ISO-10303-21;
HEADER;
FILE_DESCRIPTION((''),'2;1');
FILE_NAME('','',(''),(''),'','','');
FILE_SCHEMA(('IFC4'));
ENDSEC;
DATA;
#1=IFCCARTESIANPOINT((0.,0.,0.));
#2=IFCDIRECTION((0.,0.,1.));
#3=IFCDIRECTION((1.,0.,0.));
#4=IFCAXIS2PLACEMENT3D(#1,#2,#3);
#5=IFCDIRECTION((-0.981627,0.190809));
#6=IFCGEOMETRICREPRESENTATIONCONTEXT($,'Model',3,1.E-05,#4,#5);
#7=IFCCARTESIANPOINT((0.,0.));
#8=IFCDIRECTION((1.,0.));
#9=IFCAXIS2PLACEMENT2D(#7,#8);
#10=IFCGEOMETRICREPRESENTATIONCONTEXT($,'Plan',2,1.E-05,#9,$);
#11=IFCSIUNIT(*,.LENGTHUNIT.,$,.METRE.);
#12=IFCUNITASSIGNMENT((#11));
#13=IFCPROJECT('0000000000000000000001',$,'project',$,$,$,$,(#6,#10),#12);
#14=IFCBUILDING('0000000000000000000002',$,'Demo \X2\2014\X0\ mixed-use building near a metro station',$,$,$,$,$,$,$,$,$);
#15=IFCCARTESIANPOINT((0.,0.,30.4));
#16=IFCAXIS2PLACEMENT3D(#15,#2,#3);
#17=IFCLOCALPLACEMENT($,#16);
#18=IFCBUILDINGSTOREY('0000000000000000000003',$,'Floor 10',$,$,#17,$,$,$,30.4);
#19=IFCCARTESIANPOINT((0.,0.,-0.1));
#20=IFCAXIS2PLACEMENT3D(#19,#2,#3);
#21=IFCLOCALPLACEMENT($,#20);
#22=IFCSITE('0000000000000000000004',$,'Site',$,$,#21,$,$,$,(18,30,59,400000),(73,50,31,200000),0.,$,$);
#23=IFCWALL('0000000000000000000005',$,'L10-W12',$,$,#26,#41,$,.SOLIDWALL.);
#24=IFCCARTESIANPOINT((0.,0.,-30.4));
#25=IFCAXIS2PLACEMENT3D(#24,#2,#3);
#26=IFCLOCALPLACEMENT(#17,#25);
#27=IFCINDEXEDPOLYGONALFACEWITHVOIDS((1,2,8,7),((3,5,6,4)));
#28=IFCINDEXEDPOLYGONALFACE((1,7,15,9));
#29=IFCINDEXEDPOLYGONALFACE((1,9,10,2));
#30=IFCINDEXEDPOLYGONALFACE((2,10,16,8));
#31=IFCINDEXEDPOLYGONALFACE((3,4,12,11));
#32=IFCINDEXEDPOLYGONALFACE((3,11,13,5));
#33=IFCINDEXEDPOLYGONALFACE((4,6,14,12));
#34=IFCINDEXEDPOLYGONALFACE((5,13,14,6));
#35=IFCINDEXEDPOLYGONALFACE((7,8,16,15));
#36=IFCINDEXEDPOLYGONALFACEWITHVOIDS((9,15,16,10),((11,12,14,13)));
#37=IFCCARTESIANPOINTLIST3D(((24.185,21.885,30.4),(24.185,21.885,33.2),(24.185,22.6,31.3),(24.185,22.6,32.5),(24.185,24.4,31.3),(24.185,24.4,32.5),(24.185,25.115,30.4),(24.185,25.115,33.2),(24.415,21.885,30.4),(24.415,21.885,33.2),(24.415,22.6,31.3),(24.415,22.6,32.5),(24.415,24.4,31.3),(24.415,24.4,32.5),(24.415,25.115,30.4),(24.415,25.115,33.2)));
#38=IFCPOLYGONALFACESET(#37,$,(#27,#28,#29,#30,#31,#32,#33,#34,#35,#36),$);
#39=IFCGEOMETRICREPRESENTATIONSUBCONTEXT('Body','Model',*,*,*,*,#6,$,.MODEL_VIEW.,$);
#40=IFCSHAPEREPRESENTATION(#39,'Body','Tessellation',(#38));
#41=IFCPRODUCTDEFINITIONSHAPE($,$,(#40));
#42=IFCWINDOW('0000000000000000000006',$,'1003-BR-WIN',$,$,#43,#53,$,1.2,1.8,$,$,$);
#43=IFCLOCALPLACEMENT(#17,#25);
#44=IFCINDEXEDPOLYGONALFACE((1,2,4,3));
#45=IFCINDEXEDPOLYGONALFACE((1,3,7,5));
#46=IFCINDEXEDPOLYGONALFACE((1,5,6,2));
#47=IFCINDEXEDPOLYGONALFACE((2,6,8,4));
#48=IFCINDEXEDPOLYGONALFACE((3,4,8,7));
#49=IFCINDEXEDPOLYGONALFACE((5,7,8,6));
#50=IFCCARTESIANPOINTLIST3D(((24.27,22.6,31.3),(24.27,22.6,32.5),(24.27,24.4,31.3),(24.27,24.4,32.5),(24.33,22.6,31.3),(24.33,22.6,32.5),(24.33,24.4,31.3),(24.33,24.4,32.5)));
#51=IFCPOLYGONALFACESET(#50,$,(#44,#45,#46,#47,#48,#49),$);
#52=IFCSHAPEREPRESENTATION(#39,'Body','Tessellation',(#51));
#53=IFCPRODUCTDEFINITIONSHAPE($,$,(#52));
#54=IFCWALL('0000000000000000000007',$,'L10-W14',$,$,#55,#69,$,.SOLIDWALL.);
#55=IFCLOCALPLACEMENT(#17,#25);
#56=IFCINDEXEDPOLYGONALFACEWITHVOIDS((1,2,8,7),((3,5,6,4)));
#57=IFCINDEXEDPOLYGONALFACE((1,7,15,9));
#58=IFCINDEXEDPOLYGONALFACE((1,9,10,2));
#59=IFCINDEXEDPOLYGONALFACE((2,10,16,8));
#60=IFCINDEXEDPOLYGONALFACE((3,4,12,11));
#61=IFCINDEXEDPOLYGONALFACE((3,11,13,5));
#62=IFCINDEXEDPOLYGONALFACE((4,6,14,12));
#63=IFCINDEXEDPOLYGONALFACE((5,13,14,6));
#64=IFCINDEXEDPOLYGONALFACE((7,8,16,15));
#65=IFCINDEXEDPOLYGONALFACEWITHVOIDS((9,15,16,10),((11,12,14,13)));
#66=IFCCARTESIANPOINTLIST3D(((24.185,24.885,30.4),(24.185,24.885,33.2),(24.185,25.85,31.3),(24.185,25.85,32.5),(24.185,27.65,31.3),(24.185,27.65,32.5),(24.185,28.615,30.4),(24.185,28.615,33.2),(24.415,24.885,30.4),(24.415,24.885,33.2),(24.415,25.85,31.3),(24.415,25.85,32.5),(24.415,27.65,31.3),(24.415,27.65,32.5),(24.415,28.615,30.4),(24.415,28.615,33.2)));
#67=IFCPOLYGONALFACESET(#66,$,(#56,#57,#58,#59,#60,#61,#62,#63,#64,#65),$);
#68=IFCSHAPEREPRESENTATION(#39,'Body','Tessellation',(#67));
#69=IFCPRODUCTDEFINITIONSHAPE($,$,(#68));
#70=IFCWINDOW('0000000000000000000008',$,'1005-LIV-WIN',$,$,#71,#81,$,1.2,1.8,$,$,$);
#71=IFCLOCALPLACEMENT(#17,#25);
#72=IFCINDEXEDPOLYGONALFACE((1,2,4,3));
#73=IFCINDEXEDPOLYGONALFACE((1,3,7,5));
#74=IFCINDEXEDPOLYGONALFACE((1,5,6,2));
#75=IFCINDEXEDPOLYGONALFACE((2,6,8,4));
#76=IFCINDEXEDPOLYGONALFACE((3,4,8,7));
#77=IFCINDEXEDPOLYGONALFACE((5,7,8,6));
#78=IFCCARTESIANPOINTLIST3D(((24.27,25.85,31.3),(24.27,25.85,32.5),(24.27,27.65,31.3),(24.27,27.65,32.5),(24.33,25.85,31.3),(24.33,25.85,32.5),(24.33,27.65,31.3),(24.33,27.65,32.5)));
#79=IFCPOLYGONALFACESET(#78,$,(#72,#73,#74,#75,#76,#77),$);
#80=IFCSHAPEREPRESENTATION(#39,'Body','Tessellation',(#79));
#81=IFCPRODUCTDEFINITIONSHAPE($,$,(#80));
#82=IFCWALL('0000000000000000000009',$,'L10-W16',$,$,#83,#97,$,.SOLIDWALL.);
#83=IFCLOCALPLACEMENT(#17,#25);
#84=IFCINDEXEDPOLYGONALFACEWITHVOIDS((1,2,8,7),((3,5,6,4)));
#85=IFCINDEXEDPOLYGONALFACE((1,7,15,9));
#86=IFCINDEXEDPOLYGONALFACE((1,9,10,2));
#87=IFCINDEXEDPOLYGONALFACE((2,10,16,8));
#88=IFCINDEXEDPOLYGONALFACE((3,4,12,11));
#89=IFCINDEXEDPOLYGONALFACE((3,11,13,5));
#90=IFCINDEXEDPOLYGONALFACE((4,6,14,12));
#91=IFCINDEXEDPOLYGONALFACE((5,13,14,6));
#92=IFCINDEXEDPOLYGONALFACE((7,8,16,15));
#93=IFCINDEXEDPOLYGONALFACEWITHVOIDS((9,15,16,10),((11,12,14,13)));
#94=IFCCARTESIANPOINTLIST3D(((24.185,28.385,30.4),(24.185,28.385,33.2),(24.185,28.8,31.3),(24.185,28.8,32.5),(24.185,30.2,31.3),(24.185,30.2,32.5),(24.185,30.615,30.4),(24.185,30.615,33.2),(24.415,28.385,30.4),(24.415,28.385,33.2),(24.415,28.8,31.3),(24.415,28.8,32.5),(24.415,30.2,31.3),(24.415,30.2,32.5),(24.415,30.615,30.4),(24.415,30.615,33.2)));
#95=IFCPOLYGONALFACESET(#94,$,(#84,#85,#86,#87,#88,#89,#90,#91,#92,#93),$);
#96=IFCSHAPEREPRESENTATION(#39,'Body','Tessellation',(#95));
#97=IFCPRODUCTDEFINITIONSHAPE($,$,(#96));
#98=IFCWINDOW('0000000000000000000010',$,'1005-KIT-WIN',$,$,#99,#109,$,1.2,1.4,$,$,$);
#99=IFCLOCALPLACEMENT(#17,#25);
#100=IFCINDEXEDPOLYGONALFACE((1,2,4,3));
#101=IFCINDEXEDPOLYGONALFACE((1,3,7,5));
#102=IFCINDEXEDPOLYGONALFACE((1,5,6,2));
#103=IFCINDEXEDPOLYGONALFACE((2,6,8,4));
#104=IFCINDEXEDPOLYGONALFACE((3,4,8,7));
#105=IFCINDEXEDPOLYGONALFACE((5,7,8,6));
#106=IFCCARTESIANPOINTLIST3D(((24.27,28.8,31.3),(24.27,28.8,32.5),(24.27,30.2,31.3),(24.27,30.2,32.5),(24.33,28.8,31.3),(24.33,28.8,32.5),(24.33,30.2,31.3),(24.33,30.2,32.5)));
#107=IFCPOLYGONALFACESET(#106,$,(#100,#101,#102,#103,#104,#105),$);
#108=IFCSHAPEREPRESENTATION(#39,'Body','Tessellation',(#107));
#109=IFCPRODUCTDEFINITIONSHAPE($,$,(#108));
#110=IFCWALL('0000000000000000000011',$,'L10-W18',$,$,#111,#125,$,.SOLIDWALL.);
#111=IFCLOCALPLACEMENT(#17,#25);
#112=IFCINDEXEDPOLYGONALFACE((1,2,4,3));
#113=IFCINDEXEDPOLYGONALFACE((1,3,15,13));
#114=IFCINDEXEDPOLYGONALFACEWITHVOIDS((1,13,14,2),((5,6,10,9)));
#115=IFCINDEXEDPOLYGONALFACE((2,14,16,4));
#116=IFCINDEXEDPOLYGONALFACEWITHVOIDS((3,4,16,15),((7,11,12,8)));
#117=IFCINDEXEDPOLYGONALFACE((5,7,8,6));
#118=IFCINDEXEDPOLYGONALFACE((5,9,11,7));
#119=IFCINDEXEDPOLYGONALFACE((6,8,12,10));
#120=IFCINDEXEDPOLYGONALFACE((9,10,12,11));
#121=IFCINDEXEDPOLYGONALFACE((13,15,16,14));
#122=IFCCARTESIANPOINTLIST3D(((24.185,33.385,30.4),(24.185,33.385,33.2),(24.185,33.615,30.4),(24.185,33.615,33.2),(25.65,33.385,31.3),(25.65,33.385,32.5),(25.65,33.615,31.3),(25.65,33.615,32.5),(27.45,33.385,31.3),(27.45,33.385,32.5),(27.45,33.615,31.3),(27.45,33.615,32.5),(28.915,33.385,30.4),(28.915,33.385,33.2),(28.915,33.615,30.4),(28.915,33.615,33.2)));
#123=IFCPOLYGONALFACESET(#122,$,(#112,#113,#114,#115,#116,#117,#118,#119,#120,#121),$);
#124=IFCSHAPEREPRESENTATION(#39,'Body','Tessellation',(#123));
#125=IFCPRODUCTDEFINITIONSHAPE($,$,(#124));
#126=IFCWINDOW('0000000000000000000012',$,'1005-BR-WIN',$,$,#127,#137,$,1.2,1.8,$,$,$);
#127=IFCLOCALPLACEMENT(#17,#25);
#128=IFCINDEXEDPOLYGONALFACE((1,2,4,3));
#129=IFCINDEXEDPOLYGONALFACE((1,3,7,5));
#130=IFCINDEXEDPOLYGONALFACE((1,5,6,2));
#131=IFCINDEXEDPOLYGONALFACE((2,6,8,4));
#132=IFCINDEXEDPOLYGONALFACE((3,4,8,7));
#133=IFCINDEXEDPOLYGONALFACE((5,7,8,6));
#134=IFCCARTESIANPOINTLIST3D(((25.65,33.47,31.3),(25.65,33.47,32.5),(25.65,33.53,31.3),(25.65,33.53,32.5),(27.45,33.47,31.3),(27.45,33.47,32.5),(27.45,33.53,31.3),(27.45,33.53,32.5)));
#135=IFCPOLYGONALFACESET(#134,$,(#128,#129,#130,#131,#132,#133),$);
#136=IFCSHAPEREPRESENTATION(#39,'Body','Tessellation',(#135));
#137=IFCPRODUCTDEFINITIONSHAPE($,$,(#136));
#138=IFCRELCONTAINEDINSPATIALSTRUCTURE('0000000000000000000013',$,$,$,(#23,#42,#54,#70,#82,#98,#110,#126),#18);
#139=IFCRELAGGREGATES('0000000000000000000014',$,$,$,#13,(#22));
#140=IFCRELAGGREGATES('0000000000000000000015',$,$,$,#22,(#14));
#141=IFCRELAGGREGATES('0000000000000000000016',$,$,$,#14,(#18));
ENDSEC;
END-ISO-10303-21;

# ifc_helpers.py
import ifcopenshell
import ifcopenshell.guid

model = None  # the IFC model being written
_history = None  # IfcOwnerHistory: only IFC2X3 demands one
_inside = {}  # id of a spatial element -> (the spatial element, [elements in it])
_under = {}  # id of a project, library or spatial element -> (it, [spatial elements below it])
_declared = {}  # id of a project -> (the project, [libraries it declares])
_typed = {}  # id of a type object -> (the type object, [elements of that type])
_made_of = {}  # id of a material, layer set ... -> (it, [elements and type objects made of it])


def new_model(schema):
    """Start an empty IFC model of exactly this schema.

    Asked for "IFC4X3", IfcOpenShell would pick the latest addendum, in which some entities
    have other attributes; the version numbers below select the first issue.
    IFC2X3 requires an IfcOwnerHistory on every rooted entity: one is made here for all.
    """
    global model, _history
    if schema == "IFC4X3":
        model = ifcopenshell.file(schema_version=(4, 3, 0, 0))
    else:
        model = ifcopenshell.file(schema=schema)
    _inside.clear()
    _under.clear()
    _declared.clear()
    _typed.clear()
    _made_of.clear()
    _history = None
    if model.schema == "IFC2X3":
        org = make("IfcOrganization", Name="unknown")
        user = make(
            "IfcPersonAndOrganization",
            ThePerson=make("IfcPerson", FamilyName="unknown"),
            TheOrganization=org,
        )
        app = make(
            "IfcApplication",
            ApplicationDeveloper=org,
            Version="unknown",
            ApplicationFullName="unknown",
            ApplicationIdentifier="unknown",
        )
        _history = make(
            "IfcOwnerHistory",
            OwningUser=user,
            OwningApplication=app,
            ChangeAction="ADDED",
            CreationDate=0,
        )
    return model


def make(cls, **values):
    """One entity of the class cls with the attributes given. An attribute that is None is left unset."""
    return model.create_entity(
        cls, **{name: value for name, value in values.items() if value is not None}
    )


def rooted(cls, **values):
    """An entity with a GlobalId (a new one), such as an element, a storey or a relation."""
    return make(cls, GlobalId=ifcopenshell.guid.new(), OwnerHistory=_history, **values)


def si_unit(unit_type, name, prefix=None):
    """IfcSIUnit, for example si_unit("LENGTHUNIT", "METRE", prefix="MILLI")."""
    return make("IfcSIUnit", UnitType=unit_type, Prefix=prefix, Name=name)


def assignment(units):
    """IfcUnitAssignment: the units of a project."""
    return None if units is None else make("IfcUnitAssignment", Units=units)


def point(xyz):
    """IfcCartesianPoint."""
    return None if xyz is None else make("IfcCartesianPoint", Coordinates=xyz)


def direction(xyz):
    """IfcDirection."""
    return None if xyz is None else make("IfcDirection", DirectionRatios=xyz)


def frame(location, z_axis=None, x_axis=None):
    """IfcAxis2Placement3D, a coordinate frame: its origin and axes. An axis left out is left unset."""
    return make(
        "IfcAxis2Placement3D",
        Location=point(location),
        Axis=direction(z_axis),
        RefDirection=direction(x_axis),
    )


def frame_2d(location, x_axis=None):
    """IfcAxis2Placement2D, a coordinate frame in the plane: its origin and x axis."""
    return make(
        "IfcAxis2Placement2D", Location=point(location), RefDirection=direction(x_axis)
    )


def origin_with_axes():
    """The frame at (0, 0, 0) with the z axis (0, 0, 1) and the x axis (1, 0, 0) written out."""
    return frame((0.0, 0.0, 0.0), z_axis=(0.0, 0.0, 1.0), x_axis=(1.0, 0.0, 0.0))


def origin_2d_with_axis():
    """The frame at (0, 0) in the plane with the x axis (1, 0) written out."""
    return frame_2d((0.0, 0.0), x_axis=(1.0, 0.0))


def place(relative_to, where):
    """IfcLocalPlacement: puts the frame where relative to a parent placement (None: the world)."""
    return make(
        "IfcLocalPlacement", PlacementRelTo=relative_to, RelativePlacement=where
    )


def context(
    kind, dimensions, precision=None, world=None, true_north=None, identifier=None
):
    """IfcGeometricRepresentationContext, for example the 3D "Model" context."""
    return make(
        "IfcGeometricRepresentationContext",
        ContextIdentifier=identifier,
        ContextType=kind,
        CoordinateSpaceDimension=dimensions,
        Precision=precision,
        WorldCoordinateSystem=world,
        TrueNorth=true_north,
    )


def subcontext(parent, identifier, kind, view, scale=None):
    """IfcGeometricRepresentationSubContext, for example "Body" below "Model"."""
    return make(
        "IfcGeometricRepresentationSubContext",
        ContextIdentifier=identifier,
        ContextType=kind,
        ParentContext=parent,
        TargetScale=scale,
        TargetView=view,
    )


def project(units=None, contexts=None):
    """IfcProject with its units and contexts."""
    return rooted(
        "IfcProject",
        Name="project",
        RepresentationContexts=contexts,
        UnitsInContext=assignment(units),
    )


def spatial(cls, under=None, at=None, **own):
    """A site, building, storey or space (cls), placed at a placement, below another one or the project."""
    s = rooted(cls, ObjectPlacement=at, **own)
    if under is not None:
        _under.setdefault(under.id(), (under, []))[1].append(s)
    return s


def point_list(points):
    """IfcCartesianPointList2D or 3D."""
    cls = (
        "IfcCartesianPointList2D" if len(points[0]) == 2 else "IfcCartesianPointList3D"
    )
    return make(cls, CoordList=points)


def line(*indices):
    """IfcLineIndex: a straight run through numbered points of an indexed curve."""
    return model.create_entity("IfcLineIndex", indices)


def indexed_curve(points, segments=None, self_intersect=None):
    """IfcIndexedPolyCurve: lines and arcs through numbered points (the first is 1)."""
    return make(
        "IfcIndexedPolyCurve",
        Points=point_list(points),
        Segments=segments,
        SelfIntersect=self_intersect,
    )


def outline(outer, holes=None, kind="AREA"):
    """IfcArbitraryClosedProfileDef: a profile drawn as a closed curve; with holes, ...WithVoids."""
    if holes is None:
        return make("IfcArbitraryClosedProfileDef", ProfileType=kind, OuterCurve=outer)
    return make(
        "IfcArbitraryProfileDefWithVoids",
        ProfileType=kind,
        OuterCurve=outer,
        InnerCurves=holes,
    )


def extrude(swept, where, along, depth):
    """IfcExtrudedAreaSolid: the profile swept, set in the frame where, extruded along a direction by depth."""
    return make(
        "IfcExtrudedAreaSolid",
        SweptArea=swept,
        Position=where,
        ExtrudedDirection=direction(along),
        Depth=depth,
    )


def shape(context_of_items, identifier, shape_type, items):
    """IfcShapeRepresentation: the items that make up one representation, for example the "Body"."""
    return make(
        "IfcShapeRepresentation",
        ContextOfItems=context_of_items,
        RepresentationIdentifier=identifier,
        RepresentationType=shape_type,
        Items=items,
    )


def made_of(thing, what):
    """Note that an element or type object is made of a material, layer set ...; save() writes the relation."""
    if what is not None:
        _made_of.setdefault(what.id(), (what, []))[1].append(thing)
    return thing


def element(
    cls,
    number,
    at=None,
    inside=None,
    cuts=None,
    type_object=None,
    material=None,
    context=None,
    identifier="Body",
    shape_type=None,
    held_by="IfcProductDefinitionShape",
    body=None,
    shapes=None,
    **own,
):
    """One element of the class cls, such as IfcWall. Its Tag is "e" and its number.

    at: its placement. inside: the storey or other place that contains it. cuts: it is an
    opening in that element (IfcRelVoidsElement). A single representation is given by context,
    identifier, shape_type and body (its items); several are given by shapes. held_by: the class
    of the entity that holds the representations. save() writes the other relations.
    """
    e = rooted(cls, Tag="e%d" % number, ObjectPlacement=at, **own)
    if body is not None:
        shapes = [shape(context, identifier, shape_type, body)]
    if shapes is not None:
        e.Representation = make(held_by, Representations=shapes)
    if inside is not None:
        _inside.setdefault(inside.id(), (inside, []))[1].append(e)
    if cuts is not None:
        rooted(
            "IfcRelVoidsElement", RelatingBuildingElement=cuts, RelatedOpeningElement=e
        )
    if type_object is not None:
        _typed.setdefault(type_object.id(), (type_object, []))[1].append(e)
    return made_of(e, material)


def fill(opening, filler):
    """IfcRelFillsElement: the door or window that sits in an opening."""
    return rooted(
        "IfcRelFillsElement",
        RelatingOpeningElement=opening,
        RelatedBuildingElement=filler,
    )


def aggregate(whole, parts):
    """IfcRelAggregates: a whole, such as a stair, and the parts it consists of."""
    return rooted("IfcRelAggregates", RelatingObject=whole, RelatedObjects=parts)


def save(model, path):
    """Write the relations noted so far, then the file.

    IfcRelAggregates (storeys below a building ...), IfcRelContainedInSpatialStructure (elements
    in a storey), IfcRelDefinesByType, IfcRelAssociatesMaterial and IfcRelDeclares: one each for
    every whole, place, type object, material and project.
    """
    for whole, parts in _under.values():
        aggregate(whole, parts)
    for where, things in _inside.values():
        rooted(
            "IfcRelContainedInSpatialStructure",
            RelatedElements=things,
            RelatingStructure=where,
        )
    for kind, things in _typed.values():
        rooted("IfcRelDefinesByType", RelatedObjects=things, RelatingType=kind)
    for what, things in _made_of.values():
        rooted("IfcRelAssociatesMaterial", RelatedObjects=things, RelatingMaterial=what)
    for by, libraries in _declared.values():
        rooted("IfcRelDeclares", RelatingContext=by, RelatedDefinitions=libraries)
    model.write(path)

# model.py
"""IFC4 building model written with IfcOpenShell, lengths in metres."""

from ifc_helpers import new_model, si_unit, direction, frame, origin_with_axes, origin_2d_with_axis, place, context, subcontext, project, spatial, line, indexed_curve, outline, extrude, element, fill, save


model = new_model("IFC4")

# Units and contexts
model_context = context("Model", 3, precision=1e-05, world=origin_with_axes(), true_north=direction((-0.981627, 0.190809)))
plan_context = context("Plan", 2, precision=1e-05, world=origin_2d_with_axis())
body_context = subcontext(model_context, "Body", "Model", "MODEL_VIEW")
ifc_project = project(units=[si_unit("LENGTHUNIT", "METRE")], contexts=[model_context, plan_context])

# Site, building, storey
site_placement = place(None, frame((0.0, 0.0, -0.1), z_axis=(0.0, 0.0, 1.0), x_axis=(1.0, 0.0, 0.0)))
site = spatial("IfcSite", under=ifc_project, at=site_placement, Name="Site", RefLatitude=(18, 30, 59, 400000), RefLongitude=(73, 50, 31, 200000), RefElevation=0.0)
building = spatial("IfcBuilding", under=site, Name="Demo — mixed-use building near a metro station")
storey_placement = place(None, frame((0.0, 0.0, 30.4), z_axis=(0.0, 0.0, 1.0), x_axis=(1.0, 0.0, 0.0)))
storey = spatial("IfcBuildingStorey", under=building, at=storey_placement, Name="Floor 10", Elevation=30.4)

# Wall, opening, window
wall_1_placement = place(storey_placement, frame((0.0, 0.0, -30.4), z_axis=(0.0, 0.0, 1.0), x_axis=(1.0, 0.0, 0.0)))
wall_1 = element("IfcWall", 1, at=wall_1_placement, inside=storey, Name="L10-W12", PredefinedType="SOLIDWALL", context=body_context, shape_type="SweptSolid", body=[
    extrude(outline(indexed_curve([(24.415, 25.115), (24.415, 21.885), (24.185, 21.885), (24.185, 25.115)], segments=[line(1, 2, 3, 4, 1)])), frame((0.0, 0.0, 30.4), z_axis=(0.0, 0.0, 1.0), x_axis=(1.0, 0.0, 0.0)), (0.0, 0.0, 1.0), 2.8),
])
opening_1_placement = place(wall_1_placement, origin_with_axes())
opening_1 = element("IfcOpeningElement", 2, at=opening_1_placement, cuts=wall_1, context=body_context, shape_type="SweptSolid", body=[
    extrude(outline(indexed_curve([(24.465, 24.4), (24.465, 22.6), (24.135, 22.6), (24.135, 24.4)], segments=[line(1, 2, 3, 4, 1)])), frame((0.0, 0.0, 31.3), z_axis=(0.0, 0.0, 1.0), x_axis=(1.0, 0.0, 0.0)), (0.0, 0.0, 1.0), 1.2),
])
window_1_placement = place(storey_placement, frame((0.0, 0.0, -30.4), z_axis=(0.0, 0.0, 1.0), x_axis=(1.0, 0.0, 0.0)))
window_1 = element("IfcWindow", 3, at=window_1_placement, inside=storey, Name="1003-BR-WIN", OverallHeight=1.2, OverallWidth=1.8, context=body_context, shape_type="SweptSolid", body=[
    extrude(outline(indexed_curve([(24.33, 24.4), (24.33, 22.6), (24.27, 22.6), (24.27, 24.4)], segments=[line(1, 2, 3, 4, 1)])), frame((0.0, 0.0, 31.3), z_axis=(0.0, 0.0, 1.0), x_axis=(1.0, 0.0, 0.0)), (0.0, 0.0, 1.0), 1.2),
])
fill(opening_1, window_1)

# Wall, opening, window
wall_2_placement = place(storey_placement, frame((0.0, 0.0, -30.4), z_axis=(0.0, 0.0, 1.0), x_axis=(1.0, 0.0, 0.0)))
wall_2 = element("IfcWall", 4, at=wall_2_placement, inside=storey, Name="L10-W14", PredefinedType="SOLIDWALL", context=body_context, shape_type="SweptSolid", body=[
    extrude(outline(indexed_curve([(24.415, 28.615), (24.415, 24.885), (24.185, 24.885), (24.185, 28.615)], segments=[line(1, 2, 3, 4, 1)])), frame((0.0, 0.0, 30.4), z_axis=(0.0, 0.0, 1.0), x_axis=(1.0, 0.0, 0.0)), (0.0, 0.0, 1.0), 2.8),
])
opening_2_placement = place(wall_2_placement, origin_with_axes())
opening_2 = element("IfcOpeningElement", 5, at=opening_2_placement, cuts=wall_2, context=body_context, shape_type="SweptSolid", body=[
    extrude(outline(indexed_curve([(24.465, 27.65), (24.465, 25.85), (24.135, 25.85), (24.135, 27.65)], segments=[line(1, 2, 3, 4, 1)])), frame((0.0, 0.0, 31.3), z_axis=(0.0, 0.0, 1.0), x_axis=(1.0, 0.0, 0.0)), (0.0, 0.0, 1.0), 1.2),
])
window_2_placement = place(storey_placement, frame((0.0, 0.0, -30.4), z_axis=(0.0, 0.0, 1.0), x_axis=(1.0, 0.0, 0.0)))
window_2 = element("IfcWindow", 6, at=window_2_placement, inside=storey, Name="1005-LIV-WIN", OverallHeight=1.2, OverallWidth=1.8, context=body_context, shape_type="SweptSolid", body=[
    extrude(outline(indexed_curve([(24.33, 27.65), (24.33, 25.85), (24.27, 25.85), (24.27, 27.65)], segments=[line(1, 2, 3, 4, 1)])), frame((0.0, 0.0, 31.3), z_axis=(0.0, 0.0, 1.0), x_axis=(1.0, 0.0, 0.0)), (0.0, 0.0, 1.0), 1.2),
])
fill(opening_2, window_2)

# Wall, opening, window
wall_3_placement = place(storey_placement, frame((0.0, 0.0, -30.4), z_axis=(0.0, 0.0, 1.0), x_axis=(1.0, 0.0, 0.0)))
wall_3 = element("IfcWall", 7, at=wall_3_placement, inside=storey, Name="L10-W16", PredefinedType="SOLIDWALL", context=body_context, shape_type="SweptSolid", body=[
    extrude(outline(indexed_curve([(24.415, 30.615), (24.415, 28.385), (24.185, 28.385), (24.185, 30.615)], segments=[line(1, 2, 3, 4, 1)])), frame((0.0, 0.0, 30.4), z_axis=(0.0, 0.0, 1.0), x_axis=(1.0, 0.0, 0.0)), (0.0, 0.0, 1.0), 2.8),
])
opening_3_placement = place(wall_3_placement, origin_with_axes())
opening_3 = element("IfcOpeningElement", 8, at=opening_3_placement, cuts=wall_3, context=body_context, shape_type="SweptSolid", body=[
    extrude(outline(indexed_curve([(24.465, 30.2), (24.465, 28.8), (24.135, 28.8), (24.135, 30.2)], segments=[line(1, 2, 3, 4, 1)])), frame((0.0, 0.0, 31.3), z_axis=(0.0, 0.0, 1.0), x_axis=(1.0, 0.0, 0.0)), (0.0, 0.0, 1.0), 1.2),
])
window_3_placement = place(storey_placement, frame((0.0, 0.0, -30.4), z_axis=(0.0, 0.0, 1.0), x_axis=(1.0, 0.0, 0.0)))
window_3 = element("IfcWindow", 9, at=window_3_placement, inside=storey, Name="1005-KIT-WIN", OverallHeight=1.2, OverallWidth=1.4, context=body_context, shape_type="SweptSolid", body=[
    extrude(outline(indexed_curve([(24.33, 30.2), (24.33, 28.8), (24.27, 28.8), (24.27, 30.2)], segments=[line(1, 2, 3, 4, 1)])), frame((0.0, 0.0, 31.3), z_axis=(0.0, 0.0, 1.0), x_axis=(1.0, 0.0, 0.0)), (0.0, 0.0, 1.0), 1.2),
])
fill(opening_3, window_3)

# Wall, opening, window
wall_4_placement = place(storey_placement, frame((0.0, 0.0, -30.4), z_axis=(0.0, 0.0, 1.0), x_axis=(1.0, 0.0, 0.0)))
wall_4 = element("IfcWall", 10, at=wall_4_placement, inside=storey, Name="L10-W18", PredefinedType="SOLIDWALL", context=body_context, shape_type="SweptSolid", body=[
    extrude(outline(indexed_curve([(28.915, 33.385), (24.185, 33.385), (24.185, 33.615), (28.915, 33.615)], segments=[line(1, 2, 3, 4, 1)])), frame((0.0, 0.0, 30.4), z_axis=(0.0, 0.0, 1.0), x_axis=(1.0, 0.0, 0.0)), (0.0, 0.0, 1.0), 2.8),
])
opening_4_placement = place(wall_4_placement, origin_with_axes())
opening_4 = element("IfcOpeningElement", 11, at=opening_4_placement, cuts=wall_4, context=body_context, shape_type="SweptSolid", body=[
    extrude(outline(indexed_curve([(27.45, 33.335), (25.65, 33.335), (25.65, 33.665), (27.45, 33.665)], segments=[line(1, 2, 3, 4, 1)])), frame((0.0, 0.0, 31.3), z_axis=(0.0, 0.0, 1.0), x_axis=(1.0, 0.0, 0.0)), (0.0, 0.0, 1.0), 1.2),
])
window_4_placement = place(storey_placement, frame((0.0, 0.0, -30.4), z_axis=(0.0, 0.0, 1.0), x_axis=(1.0, 0.0, 0.0)))
window_4 = element("IfcWindow", 12, at=window_4_placement, inside=storey, Name="1005-BR-WIN", OverallHeight=1.2, OverallWidth=1.8, context=body_context, shape_type="SweptSolid", body=[
    extrude(outline(indexed_curve([(27.45, 33.47), (25.65, 33.47), (25.65, 33.53), (27.45, 33.53)], segments=[line(1, 2, 3, 4, 1)])), frame((0.0, 0.0, 31.3), z_axis=(0.0, 0.0, 1.0), x_axis=(1.0, 0.0, 0.0)), (0.0, 0.0, 1.0), 1.2),
])
fill(opening_4, window_4)

save(model, "model.ifc")
